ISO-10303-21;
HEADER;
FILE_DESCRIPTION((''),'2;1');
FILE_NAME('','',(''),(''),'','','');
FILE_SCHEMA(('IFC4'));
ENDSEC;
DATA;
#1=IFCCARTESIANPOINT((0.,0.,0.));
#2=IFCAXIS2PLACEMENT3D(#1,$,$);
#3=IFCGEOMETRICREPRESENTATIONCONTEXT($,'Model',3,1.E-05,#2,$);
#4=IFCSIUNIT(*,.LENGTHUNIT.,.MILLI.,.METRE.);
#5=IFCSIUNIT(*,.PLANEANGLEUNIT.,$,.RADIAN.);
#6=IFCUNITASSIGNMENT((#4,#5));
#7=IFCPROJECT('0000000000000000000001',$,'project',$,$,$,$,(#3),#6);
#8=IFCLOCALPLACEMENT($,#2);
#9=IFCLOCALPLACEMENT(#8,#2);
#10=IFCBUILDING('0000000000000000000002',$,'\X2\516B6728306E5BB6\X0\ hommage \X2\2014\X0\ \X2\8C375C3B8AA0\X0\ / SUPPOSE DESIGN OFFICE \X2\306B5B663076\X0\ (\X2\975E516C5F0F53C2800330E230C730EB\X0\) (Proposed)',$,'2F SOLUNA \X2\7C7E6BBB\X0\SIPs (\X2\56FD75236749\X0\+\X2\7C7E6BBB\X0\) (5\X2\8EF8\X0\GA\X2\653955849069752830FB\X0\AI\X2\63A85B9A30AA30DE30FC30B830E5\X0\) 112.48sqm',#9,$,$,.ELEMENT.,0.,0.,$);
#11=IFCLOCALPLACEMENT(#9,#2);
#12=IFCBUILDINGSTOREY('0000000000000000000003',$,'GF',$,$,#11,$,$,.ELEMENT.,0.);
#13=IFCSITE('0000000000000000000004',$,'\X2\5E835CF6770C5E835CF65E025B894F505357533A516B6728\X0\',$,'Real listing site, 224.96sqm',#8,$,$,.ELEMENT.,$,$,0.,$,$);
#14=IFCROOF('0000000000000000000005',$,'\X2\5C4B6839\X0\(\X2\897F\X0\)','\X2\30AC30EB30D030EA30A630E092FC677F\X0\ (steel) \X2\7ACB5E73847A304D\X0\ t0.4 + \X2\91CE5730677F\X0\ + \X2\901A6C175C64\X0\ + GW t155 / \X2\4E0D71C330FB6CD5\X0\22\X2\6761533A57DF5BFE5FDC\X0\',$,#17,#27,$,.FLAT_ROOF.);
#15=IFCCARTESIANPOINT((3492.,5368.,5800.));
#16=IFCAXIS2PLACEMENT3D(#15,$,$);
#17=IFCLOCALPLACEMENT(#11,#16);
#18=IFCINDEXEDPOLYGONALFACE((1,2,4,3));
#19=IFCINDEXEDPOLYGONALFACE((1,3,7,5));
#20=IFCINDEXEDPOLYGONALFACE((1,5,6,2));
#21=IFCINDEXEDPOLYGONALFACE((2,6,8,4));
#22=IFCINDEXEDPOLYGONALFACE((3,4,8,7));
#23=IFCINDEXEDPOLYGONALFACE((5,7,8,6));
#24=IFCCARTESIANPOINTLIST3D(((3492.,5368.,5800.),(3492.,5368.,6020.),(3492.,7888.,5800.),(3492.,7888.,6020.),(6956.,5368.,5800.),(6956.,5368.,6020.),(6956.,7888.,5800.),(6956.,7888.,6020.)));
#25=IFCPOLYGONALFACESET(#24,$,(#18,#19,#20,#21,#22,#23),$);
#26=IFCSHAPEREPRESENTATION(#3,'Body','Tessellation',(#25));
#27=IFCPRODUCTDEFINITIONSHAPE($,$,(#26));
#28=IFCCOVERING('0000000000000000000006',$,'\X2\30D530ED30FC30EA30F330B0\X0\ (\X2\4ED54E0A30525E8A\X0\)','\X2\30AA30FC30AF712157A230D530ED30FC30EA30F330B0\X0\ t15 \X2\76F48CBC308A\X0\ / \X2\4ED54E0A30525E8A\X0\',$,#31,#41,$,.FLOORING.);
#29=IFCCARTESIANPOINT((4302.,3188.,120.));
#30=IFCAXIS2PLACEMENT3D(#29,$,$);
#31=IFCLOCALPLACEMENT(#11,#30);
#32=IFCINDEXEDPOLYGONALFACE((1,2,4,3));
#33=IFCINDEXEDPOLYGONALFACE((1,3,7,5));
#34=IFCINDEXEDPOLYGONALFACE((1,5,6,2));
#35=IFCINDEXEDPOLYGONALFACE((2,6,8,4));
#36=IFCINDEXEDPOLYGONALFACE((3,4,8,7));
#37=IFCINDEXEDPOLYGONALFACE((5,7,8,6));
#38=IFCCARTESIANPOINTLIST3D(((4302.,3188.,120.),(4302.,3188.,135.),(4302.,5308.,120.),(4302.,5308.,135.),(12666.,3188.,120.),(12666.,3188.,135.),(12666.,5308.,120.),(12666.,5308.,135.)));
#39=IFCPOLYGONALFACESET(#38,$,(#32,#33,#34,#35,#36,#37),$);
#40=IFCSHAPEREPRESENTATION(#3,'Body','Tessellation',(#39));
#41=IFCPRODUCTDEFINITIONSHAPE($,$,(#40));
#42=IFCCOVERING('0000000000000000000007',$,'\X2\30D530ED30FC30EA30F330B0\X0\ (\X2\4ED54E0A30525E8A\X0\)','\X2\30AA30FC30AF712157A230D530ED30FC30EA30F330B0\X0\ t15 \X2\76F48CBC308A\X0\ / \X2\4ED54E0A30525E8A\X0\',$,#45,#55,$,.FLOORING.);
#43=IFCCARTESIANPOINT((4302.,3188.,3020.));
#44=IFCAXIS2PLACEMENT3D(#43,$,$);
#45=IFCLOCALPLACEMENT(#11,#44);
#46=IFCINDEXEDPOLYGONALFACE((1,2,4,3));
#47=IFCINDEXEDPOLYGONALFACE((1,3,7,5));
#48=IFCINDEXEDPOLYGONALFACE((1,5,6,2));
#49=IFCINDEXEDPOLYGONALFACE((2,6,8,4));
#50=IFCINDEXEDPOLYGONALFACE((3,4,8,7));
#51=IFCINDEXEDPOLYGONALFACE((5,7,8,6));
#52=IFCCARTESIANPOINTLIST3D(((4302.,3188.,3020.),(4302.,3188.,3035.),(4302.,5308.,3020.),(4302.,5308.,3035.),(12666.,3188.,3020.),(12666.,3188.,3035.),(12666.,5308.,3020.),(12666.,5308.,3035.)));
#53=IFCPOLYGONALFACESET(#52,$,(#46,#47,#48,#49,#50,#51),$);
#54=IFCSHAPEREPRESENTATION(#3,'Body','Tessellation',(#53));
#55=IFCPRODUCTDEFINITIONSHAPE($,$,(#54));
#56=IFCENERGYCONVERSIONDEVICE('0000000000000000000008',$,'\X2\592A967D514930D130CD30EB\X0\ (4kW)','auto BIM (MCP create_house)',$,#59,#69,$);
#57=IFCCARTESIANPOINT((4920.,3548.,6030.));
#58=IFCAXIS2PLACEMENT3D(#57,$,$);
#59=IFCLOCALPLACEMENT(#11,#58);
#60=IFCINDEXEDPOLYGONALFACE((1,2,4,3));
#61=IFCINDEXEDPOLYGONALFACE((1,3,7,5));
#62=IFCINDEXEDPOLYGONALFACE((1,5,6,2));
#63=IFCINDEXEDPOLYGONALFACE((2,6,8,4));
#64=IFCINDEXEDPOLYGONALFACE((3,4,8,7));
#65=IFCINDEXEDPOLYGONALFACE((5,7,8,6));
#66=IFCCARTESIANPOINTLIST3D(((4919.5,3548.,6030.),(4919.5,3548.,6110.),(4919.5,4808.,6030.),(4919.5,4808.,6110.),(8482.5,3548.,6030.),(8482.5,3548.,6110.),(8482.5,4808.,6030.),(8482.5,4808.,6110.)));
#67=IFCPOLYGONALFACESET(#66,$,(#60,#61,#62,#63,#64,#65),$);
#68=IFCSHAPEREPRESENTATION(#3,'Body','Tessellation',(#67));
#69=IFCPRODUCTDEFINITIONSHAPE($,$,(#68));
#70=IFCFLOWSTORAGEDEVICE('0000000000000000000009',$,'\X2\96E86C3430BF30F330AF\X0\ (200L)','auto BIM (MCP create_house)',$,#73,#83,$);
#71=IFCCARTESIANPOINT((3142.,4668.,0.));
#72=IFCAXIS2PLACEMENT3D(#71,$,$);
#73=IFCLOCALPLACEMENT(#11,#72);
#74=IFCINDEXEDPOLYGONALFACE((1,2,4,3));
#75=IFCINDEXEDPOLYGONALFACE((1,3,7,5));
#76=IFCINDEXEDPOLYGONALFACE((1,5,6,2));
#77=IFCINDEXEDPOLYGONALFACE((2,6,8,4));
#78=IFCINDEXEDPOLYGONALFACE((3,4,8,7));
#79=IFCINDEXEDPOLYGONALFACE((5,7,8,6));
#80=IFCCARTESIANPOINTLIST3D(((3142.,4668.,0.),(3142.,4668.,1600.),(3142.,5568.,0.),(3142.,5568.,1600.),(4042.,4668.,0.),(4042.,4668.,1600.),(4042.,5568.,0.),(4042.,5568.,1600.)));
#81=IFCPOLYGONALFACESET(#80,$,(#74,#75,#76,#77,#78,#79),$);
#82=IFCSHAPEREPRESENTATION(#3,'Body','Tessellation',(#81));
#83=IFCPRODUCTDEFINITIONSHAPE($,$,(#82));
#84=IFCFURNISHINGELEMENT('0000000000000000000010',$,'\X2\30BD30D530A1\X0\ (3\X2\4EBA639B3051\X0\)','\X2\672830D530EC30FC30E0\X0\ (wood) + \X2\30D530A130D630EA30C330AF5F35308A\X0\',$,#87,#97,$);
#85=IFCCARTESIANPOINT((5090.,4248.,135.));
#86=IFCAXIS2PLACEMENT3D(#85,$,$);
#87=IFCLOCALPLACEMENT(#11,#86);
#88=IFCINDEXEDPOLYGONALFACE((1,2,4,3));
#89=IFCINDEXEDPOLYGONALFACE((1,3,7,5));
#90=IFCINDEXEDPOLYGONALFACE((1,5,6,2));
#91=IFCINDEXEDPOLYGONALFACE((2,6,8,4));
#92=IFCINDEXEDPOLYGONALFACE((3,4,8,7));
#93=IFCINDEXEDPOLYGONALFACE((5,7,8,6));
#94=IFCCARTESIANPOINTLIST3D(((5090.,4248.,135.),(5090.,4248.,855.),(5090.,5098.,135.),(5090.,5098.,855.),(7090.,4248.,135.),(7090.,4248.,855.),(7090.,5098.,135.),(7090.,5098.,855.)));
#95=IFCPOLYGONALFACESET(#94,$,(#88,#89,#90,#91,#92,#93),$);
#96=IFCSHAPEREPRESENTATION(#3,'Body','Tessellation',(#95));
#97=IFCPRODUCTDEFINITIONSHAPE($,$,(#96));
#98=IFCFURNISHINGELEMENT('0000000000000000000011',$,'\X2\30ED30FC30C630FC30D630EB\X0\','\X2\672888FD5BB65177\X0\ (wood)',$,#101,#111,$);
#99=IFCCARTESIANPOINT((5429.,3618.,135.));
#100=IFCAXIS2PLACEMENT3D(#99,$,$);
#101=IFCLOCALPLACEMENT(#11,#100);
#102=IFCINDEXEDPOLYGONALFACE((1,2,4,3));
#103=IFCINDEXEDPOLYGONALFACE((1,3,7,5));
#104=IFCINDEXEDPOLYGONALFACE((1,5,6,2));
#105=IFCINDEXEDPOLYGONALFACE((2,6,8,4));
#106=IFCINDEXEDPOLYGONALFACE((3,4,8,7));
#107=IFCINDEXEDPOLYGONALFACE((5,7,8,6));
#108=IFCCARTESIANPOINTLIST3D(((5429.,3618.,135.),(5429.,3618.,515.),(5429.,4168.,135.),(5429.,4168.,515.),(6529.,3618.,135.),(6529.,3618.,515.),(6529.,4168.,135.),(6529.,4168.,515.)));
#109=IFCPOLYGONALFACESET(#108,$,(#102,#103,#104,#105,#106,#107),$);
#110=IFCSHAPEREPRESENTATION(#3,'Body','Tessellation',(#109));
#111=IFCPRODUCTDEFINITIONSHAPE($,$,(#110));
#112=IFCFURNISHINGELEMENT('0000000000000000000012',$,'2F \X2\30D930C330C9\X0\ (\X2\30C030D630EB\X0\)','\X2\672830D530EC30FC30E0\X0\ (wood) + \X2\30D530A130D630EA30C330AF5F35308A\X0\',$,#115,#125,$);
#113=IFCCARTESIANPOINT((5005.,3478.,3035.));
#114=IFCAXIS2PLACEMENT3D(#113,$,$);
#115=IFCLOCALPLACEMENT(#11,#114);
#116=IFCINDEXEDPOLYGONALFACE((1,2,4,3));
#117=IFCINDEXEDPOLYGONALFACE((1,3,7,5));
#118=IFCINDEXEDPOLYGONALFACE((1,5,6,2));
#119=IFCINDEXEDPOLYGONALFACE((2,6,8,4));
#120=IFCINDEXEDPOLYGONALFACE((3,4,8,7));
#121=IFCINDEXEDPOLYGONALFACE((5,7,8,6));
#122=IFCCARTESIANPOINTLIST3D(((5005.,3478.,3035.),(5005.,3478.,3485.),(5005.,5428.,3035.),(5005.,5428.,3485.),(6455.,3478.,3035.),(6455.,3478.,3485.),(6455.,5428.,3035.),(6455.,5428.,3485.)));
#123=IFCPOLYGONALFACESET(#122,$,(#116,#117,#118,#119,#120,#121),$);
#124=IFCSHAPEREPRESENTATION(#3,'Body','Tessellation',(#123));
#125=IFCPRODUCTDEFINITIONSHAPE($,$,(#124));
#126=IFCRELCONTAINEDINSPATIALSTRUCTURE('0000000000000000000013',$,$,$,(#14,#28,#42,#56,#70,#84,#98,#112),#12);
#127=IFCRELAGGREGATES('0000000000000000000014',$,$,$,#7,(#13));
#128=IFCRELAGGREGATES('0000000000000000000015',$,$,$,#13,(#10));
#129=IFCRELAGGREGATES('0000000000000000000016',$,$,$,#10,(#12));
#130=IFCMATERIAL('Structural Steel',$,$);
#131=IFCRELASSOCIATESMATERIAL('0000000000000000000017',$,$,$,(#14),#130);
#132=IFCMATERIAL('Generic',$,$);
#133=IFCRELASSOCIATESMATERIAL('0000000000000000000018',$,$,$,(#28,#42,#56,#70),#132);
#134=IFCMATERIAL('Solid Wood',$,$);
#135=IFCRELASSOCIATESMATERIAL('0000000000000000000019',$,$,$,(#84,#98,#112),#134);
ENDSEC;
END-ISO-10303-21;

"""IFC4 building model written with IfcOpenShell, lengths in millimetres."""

from ifc_helpers import new_model, si_unit, frame, frame_2d, origin, place, context, project, spatial, rectangle, extrude, material, element, save


model = new_model("IFC4")

# Units and contexts
model_context = context("Model", 3, precision=1e-05, world=origin())
ifc_project = project(units=[si_unit("LENGTHUNIT", "METRE", prefix="MILLI"), si_unit("PLANEANGLEUNIT", "RADIAN")], contexts=[model_context])

# Site, building, storey
site_placement = place(None, origin())
site = spatial("IfcSite", under=ifc_project, at=site_placement, Name="広島県広島市安佐南区八木", ObjectType="Real listing site, 224.96sqm", CompositionType="ELEMENT", RefElevation=0.0)
building_placement = place(site_placement, origin())
building = spatial("IfcBuilding", under=site, at=building_placement, Name="八木の家 hommage — 谷尻誠 / SUPPOSE DESIGN OFFICE に学ぶ (非公式参考モデル) (Proposed)", ObjectType="2F SOLUNA 籾殻SIPs (国産杉+籾殻) (5軸GA改善適用・AI推定オマージュ) 112.48sqm", CompositionType="ELEMENT", ElevationOfRefHeight=0.0, ElevationOfTerrain=0.0)
storey_placement = place(building_placement, origin())
storey = spatial("IfcBuildingStorey", under=building, at=storey_placement, Name="GF", CompositionType="ELEMENT", Elevation=0.0)

# Shared definitions
ifc_material_1 = material(Name="Solid Wood")

# Roof
ifc_material_2 = material(Name="Structural Steel")
roof_1_placement = place(storey_placement, frame((3492.0, 5368.0, 5800.0)))
element("IfcRoof", 1, at=roof_1_placement, inside=storey, material=ifc_material_2, Name="屋根(西)", Description="ガルバリウム鋼板 (steel) 立平葺き t0.4 + 野地板 + 通気層 + GW t155 / 不燃・法22条区域対応", PredefinedType="FLAT_ROOF", context=model_context, shape_type="SweptSolid", body=[
    extrude(rectangle(XDim=3464.0, YDim=2520.0, at=frame_2d((1732.0, 1260.0))), frame((3492.0, 5368.0, 5800.0)), (0.0, 0.0, 1.0), 220.0),
])

# Coverings
ifc_material_3 = material(Name="Generic")
covering_1_placement = place(storey_placement, frame((4302.0, 3188.0, 120.0)))
element("IfcCovering", 2, at=covering_1_placement, inside=storey, material=ifc_material_3, Name="フローリング (仕上げ床)", Description="オーク無垢フローリング t15 直貼り / 仕上げ床", PredefinedType="FLOORING", context=model_context, shape_type="SweptSolid", body=[
    extrude(rectangle(XDim=8364.0, YDim=2120.0, at=frame_2d((4182.0, 1060.0))), frame((4302.0, 3188.0, 120.0)), (0.0, 0.0, 1.0), 15.0),
])
covering_2_placement = place(storey_placement, frame((4302.0, 3188.0, 3020.0)))
element("IfcCovering", 3, at=covering_2_placement, inside=storey, material=ifc_material_3, Name="フローリング (仕上げ床)", Description="オーク無垢フローリング t15 直貼り / 仕上げ床", PredefinedType="FLOORING", context=model_context, shape_type="SweptSolid", body=[
    extrude(rectangle(XDim=8364.0, YDim=2120.0, at=frame_2d((4182.0, 1060.0))), frame((4302.0, 3188.0, 3020.0)), (0.0, 0.0, 1.0), 15.0),
])

# Energy conversion device
energy_conversion_device_placement = place(storey_placement, frame((4920.0, 3548.0, 6030.0)))
element("IfcEnergyConversionDevice", 4, at=energy_conversion_device_placement, inside=storey, material=ifc_material_3, Name="太陽光パネル (4kW)", Description="auto BIM (MCP create_house)", context=model_context, shape_type="SweptSolid", body=[
    extrude(rectangle(XDim=3563.0, YDim=1260.0, at=frame_2d((1781.0, 630.0))), frame((4920.0, 3548.0, 6030.0)), (0.0, 0.0, 1.0), 80.0),
])

# Flow storage device
flow_storage_device_placement = place(storey_placement, frame((3142.0, 4668.0, 0.0)))
element("IfcFlowStorageDevice", 5, at=flow_storage_device_placement, inside=storey, material=ifc_material_3, Name="雨水タンク (200L)", Description="auto BIM (MCP create_house)", context=model_context, shape_type="SweptSolid", body=[
    extrude(rectangle(XDim=900.0, YDim=900.0, at=frame_2d((450.0, 450.0))), frame((3142.0, 4668.0, 0.0)), (0.0, 0.0, 1.0), 1600.0),
])

# Furnishing elements
furnishing_1_placement = place(storey_placement, frame((5090.0, 4248.0, 135.0)))
element("IfcFurnishingElement", 6, at=furnishing_1_placement, inside=storey, material=ifc_material_1, Name="ソファ (3人掛け)", Description="木フレーム (wood) + ファブリック張り", context=model_context, shape_type="SweptSolid", body=[
    extrude(rectangle(XDim=2000.0, YDim=850.0, at=frame_2d((1000.0, 425.0))), frame((5090.0, 4248.0, 135.0)), (0.0, 0.0, 1.0), 720.0),
])
furnishing_2_placement = place(storey_placement, frame((5429.0, 3618.0, 135.0)))
element("IfcFurnishingElement", 7, at=furnishing_2_placement, inside=storey, material=ifc_material_1, Name="ローテーブル", Description="木製家具 (wood)", context=model_context, shape_type="SweptSolid", body=[
    extrude(rectangle(XDim=1100.0, YDim=550.0, at=frame_2d((550.0, 275.0))), frame((5429.0, 3618.0, 135.0)), (0.0, 0.0, 1.0), 380.0),
])
furnishing_3_placement = place(storey_placement, frame((5005.0, 3478.0, 3035.0)))
element("IfcFurnishingElement", 8, at=furnishing_3_placement, inside=storey, material=ifc_material_1, Name="2F ベッド (ダブル)", Description="木フレーム (wood) + ファブリック張り", context=model_context, shape_type="SweptSolid", body=[
    extrude(rectangle(XDim=1450.0, YDim=1950.0, at=frame_2d((725.0, 975.0))), frame((5005.0, 3478.0, 3035.0)), (0.0, 0.0, 1.0), 450.0),
])

save(model, "model.ifc")
